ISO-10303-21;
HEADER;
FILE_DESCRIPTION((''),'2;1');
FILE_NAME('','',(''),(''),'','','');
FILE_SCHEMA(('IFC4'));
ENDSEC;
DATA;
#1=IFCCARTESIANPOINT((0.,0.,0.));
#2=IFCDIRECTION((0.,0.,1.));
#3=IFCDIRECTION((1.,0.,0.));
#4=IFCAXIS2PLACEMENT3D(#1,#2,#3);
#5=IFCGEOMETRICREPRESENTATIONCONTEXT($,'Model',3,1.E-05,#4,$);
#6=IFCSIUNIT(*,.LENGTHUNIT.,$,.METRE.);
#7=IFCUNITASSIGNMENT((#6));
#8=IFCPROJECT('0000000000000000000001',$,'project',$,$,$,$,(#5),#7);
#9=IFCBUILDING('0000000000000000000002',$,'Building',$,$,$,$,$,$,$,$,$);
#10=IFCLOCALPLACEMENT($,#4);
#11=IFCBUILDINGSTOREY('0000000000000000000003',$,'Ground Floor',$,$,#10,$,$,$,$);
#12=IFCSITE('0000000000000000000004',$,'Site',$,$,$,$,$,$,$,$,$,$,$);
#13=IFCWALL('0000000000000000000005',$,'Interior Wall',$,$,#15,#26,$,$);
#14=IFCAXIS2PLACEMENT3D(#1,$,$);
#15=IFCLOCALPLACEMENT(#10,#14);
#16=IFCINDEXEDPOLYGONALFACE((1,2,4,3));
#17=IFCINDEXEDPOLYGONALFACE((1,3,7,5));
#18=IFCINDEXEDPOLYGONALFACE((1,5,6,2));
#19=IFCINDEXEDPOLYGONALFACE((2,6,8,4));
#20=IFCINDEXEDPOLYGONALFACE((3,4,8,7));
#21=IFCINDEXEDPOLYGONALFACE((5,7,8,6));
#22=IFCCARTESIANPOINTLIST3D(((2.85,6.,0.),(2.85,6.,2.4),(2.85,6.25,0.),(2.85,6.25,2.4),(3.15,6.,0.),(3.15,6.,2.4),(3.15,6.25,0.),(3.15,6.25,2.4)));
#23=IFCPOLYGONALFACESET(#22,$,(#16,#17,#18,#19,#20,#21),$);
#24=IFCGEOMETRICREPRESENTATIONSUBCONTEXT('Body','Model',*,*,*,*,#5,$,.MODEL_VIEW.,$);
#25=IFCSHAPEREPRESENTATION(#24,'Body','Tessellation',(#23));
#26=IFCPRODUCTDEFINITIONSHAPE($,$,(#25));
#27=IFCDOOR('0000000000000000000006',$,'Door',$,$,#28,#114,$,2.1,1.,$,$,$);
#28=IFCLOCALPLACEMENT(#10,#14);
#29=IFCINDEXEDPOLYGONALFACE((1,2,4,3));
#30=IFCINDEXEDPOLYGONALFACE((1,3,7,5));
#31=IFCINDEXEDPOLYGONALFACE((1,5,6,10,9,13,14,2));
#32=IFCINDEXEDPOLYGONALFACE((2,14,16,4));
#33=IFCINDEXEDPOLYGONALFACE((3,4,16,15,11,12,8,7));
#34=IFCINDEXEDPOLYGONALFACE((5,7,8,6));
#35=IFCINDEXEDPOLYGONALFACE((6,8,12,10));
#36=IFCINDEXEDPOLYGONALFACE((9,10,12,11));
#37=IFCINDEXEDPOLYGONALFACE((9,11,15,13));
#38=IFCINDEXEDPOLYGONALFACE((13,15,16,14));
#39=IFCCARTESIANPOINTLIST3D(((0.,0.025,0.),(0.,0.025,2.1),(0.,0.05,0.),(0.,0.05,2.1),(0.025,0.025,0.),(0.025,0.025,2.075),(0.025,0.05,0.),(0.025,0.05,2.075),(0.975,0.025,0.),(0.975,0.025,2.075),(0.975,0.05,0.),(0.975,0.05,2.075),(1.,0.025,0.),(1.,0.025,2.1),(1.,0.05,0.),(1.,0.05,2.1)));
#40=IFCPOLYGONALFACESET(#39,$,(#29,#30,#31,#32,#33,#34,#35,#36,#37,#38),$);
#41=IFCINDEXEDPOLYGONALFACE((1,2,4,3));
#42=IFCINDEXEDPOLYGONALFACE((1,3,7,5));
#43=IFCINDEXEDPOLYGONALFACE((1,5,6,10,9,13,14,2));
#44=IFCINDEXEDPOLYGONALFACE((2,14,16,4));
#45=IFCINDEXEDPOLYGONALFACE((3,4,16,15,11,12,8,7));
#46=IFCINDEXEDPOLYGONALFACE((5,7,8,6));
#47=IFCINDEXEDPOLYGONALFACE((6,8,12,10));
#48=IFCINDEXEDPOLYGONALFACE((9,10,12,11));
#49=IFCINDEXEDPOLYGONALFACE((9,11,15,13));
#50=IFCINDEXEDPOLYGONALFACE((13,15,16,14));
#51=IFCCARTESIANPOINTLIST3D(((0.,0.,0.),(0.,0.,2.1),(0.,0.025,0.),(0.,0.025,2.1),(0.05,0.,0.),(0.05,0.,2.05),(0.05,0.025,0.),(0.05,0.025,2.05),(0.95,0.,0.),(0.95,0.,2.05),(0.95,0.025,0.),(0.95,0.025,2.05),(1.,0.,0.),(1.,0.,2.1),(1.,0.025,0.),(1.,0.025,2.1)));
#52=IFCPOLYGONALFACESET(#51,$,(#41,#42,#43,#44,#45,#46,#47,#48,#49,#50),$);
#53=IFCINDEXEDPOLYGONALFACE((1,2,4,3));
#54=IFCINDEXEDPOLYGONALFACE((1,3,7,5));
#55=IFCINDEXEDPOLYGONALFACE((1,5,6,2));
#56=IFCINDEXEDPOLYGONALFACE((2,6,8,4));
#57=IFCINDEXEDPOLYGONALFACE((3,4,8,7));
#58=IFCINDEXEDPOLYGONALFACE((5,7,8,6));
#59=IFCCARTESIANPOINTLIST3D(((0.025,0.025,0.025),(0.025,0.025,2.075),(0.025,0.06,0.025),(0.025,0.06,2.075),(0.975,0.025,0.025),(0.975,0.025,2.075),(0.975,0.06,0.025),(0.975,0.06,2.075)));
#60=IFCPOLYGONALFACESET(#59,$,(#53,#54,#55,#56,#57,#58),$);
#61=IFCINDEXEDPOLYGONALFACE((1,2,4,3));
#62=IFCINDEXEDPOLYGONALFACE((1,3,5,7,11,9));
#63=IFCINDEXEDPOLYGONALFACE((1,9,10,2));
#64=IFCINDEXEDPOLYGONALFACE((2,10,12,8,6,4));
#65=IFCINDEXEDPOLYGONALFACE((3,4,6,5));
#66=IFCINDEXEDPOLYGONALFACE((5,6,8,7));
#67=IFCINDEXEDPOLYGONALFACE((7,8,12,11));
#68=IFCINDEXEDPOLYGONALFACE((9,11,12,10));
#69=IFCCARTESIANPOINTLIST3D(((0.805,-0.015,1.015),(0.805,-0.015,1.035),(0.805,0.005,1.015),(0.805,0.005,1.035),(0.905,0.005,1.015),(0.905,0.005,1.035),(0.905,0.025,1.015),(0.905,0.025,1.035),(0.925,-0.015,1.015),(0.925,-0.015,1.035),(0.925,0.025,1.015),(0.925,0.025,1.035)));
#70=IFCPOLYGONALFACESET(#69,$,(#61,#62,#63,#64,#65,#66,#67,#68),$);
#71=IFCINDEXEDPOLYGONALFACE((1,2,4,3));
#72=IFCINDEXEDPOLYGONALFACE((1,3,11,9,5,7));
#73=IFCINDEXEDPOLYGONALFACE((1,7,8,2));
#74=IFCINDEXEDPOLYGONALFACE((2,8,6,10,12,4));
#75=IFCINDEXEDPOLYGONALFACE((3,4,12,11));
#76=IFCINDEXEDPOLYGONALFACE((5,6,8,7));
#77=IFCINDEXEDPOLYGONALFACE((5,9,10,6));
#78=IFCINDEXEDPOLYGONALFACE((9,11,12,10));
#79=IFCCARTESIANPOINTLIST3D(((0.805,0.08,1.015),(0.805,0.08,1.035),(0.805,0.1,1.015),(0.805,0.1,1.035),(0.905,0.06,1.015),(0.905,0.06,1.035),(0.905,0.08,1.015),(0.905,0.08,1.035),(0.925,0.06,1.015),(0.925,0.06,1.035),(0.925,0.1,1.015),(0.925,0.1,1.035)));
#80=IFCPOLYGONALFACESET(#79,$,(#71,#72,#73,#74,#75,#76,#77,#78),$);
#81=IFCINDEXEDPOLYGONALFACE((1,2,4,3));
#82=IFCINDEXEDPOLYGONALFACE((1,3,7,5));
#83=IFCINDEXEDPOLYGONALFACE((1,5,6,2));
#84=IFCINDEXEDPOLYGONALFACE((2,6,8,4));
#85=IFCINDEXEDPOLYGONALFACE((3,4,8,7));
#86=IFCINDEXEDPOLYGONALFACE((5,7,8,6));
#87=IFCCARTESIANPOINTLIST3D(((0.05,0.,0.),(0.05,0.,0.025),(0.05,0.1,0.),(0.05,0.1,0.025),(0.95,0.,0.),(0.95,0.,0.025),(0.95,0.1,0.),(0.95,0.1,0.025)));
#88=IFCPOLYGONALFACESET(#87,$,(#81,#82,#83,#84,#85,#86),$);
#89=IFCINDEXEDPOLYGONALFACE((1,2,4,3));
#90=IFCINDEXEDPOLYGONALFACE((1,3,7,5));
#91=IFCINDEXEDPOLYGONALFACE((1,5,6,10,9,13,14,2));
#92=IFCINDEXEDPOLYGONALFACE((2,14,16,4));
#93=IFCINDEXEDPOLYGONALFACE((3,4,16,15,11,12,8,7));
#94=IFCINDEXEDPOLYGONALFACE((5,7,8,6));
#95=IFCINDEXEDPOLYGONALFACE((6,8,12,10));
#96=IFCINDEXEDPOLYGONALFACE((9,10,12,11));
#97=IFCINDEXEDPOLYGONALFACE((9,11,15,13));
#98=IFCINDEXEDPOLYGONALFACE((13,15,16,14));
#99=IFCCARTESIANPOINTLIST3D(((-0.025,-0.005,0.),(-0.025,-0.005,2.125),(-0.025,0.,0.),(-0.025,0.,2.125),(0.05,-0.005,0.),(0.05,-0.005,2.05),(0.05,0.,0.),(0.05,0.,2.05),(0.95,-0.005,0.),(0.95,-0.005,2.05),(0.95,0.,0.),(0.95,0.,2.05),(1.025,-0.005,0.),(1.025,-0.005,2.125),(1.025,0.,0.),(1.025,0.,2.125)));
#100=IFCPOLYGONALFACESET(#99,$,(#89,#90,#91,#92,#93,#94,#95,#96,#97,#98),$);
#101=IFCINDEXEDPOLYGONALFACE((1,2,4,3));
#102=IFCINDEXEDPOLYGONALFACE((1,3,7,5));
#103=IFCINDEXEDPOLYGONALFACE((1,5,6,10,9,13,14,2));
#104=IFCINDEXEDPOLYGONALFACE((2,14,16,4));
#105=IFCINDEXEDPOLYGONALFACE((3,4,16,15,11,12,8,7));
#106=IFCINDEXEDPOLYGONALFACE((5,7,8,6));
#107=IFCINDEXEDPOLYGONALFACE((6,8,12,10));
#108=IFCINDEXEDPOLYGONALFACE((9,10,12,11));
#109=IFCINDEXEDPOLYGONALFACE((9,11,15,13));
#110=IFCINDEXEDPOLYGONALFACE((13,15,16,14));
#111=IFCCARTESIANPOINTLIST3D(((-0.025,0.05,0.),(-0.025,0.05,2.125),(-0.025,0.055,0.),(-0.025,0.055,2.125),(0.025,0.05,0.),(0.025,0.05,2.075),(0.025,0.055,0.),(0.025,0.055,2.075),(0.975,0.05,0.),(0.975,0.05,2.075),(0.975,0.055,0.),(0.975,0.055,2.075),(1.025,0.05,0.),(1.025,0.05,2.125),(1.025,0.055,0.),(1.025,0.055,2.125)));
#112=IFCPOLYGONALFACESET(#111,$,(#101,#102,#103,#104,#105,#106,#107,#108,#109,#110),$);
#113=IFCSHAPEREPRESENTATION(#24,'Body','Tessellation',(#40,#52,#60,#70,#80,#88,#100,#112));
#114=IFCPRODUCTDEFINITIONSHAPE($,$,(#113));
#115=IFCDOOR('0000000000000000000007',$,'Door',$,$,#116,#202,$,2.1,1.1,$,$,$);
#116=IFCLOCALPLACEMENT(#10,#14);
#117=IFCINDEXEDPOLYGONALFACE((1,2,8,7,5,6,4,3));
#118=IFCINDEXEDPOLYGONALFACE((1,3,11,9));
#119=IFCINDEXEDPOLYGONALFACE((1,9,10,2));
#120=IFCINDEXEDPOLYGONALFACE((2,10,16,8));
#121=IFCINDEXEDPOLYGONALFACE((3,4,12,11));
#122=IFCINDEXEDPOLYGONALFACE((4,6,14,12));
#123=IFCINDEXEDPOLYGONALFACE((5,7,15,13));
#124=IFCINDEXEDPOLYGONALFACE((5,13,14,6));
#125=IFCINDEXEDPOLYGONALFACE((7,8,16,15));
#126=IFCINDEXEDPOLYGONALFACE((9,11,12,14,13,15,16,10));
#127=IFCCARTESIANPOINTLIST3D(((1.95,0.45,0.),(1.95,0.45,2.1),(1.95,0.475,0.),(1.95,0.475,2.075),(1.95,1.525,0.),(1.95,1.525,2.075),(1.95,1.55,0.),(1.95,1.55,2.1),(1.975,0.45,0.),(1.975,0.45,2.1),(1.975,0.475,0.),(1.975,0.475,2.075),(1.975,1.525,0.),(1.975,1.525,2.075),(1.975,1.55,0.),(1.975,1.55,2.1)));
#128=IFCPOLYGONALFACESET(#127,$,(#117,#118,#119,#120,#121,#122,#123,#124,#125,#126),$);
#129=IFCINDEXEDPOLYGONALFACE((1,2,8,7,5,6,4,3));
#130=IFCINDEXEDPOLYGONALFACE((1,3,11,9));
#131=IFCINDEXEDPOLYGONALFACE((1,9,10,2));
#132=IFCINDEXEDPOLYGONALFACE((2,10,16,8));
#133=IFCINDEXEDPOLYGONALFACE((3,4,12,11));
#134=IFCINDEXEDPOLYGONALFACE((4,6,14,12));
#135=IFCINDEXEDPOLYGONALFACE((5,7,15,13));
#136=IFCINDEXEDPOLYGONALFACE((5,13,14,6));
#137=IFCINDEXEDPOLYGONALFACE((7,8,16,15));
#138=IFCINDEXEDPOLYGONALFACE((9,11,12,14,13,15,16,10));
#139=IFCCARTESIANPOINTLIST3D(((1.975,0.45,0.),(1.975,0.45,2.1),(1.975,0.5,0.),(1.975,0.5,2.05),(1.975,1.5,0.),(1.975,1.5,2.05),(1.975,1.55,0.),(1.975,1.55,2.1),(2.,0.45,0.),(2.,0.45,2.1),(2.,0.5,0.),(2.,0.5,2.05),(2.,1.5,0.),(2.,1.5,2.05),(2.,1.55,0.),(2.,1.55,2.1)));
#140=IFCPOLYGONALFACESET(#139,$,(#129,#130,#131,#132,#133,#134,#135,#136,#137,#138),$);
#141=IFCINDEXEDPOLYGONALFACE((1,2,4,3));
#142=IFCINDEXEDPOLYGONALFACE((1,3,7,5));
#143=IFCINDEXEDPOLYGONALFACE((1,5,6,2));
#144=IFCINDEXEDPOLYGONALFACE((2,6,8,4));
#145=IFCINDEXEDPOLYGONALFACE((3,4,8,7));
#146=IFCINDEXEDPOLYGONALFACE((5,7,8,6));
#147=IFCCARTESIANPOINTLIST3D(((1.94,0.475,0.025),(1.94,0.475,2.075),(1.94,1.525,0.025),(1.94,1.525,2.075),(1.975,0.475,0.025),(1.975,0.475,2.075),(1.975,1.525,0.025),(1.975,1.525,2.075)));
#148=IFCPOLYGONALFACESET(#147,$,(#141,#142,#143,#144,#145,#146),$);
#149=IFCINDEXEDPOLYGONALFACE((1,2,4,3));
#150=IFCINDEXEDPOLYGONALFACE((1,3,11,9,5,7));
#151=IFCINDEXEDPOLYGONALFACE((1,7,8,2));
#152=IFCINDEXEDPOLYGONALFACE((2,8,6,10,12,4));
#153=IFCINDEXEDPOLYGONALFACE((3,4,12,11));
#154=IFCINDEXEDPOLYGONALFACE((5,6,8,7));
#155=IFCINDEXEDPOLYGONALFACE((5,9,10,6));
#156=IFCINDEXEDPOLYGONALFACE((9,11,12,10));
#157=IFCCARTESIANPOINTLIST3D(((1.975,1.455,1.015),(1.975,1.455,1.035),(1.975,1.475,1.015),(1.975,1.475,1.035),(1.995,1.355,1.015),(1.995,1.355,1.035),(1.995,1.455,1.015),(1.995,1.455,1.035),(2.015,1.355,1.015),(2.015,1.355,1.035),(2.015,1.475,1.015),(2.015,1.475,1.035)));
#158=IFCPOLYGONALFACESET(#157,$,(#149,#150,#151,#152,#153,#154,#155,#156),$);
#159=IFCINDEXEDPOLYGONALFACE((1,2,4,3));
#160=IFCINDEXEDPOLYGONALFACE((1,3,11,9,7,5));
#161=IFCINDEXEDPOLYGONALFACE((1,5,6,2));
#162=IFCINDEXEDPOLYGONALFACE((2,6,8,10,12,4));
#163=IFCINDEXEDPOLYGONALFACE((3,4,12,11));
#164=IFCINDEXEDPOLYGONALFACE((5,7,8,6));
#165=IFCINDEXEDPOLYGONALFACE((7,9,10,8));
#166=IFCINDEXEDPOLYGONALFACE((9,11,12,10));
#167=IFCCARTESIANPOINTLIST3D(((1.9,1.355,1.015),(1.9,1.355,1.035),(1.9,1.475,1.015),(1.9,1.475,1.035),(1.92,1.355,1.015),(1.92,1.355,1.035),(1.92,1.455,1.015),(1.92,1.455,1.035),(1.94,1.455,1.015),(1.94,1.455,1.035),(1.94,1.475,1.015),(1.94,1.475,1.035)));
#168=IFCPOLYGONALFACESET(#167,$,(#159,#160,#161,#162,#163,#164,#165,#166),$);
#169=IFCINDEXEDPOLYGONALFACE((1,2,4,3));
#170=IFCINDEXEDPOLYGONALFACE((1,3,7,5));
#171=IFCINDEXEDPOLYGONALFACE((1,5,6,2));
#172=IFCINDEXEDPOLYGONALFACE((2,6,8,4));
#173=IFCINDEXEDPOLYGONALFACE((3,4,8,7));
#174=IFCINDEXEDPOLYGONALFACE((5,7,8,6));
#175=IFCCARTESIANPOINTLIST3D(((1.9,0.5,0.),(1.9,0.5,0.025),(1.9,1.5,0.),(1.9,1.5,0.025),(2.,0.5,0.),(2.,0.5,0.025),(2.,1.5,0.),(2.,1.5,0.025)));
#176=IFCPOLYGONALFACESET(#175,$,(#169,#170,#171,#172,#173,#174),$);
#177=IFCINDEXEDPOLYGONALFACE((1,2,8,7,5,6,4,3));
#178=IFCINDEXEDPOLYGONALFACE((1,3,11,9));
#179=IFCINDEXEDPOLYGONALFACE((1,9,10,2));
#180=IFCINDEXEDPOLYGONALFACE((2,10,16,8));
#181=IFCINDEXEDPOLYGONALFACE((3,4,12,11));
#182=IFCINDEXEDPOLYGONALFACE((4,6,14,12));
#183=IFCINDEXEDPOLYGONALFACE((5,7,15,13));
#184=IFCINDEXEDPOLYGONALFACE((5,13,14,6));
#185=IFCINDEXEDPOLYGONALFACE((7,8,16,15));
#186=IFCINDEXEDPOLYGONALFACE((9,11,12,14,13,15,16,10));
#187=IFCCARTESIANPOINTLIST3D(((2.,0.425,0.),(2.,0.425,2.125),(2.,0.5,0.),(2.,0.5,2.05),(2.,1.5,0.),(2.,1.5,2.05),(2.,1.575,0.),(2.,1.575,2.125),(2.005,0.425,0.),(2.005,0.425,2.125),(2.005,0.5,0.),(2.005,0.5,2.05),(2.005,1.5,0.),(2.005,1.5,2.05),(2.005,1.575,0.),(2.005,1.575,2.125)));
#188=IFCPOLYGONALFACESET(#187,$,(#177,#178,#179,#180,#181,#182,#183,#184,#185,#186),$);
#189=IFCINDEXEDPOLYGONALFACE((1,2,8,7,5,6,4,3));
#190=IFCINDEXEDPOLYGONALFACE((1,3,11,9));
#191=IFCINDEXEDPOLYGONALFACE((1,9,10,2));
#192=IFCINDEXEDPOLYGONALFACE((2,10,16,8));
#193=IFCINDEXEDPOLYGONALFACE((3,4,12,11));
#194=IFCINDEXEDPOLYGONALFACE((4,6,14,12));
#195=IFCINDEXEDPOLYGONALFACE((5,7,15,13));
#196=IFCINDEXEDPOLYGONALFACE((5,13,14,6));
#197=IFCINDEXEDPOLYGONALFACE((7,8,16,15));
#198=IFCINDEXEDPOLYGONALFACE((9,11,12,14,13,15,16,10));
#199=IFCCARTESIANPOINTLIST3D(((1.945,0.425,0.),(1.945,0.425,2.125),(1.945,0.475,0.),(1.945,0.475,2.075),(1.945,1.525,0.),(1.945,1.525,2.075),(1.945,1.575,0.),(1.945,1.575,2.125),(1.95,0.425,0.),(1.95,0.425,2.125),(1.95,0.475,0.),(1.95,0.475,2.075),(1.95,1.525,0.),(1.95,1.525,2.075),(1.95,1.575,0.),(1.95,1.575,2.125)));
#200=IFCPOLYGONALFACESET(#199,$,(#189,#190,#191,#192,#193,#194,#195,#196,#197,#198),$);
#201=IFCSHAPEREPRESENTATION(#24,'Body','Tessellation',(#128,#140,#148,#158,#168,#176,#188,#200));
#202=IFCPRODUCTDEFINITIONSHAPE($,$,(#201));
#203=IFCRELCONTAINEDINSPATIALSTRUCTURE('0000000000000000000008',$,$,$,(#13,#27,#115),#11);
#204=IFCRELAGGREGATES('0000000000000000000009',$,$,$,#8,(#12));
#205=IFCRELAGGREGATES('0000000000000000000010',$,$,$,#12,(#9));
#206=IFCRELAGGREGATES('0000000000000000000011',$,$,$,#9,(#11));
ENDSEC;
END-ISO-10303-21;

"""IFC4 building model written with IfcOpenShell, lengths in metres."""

from ifc_helpers import new_model, si_unit, frame, origin_with_axes, place, context, subcontext, project, spatial, line, indexed_curve, outline, extrude, element, save


model = new_model("IFC4")

# Units and contexts
model_context = context("Model", 3, precision=1e-05, world=origin_with_axes())
body_context = subcontext(model_context, "Body", "Model", "MODEL_VIEW")
ifc_project = project(units=[si_unit("LENGTHUNIT", "METRE")], contexts=[model_context])

# Site, building, storey
site = spatial("IfcSite", under=ifc_project, Name="Site")
building = spatial("IfcBuilding", under=site, Name="Building")
storey_placement = place(None, origin_with_axes())
storey = spatial("IfcBuildingStorey", under=building, at=storey_placement, Name="Ground Floor")

# Wall
wall_1_placement = place(storey_placement, frame((3.0, 6.0, 0.0), z_axis=(0.0, 0.0, 1.0), x_axis=(0.0, 1.0, 0.0)))
element("IfcWall", 1, at=wall_1_placement, inside=storey, Name="Interior Wall", context=body_context, shape_type="SweptSolid", body=[
    extrude(outline(indexed_curve([(0.0, 0.0), (0.0, 0.3), (0.25, 0.3), (0.25, 0.0), (0.0, 0.0)], self_intersect=False)), frame((0.0, -0.15, 0.0), z_axis=(0.0, 0.0, 1.0), x_axis=(1.0, 0.0, 0.0)), (0.0, 0.0, 1.0), 2.4),
])

# Doors
door_1_placement = place(storey_placement, origin_with_axes())
element("IfcDoor", 2, at=door_1_placement, inside=storey, Name="Door", OverallHeight=2.1, OverallWidth=1.0, context=body_context, shape_type="SweptSolid", body=[
    extrude(outline(indexed_curve([(0.0, 0.0), (0.0, 2.1), (1.0, 2.1), (1.0, 0.0), (0.975, 0.0), (0.975, 2.075), (0.025, 2.075), (0.025, 0.0)], segments=[line(1, 2, 3, 4, 5, 6, 7, 8, 1)])), frame((0.0, 0.025, 0.0), z_axis=(0.0, -1.0, 0.0), x_axis=(1.0, 0.0, 0.0)), (0.0, 0.0, -1.0), 0.025),
    extrude(outline(indexed_curve([(0.0, 0.0), (0.0, 2.1), (1.0, 2.1), (1.0, 0.0), (0.95, 0.0), (0.95, 2.05), (0.05, 2.05), (0.05, 0.0)], segments=[line(1, 2, 3, 4, 5, 6, 7, 8, 1)])), frame((0.0, 0.0, 0.0), z_axis=(0.0, -1.0, 0.0), x_axis=(1.0, 0.0, 0.0)), (0.0, 0.0, -1.0), 0.025),
    extrude(outline(indexed_curve([(0.0, 0.0), (0.95, 0.0), (0.95, 0.035), (0.0, 0.035)], segments=[line(1, 2, 3, 4, 1)])), frame((0.025, 0.025, 0.025), z_axis=(0.0, 0.0, 1.0), x_axis=(1.0, 0.0, 0.0)), (0.0, 0.0, 1.0), 2.05),
    extrude(outline(indexed_curve([(0.0, 0.0), (0.0, -0.04), (-0.12, -0.04), (-0.12, -0.02), (-0.02, -0.02), (-0.02, 0.0)], segments=[line(1, 2, 3, 4, 5, 6, 1)])), frame((0.925, 0.025, 1.015), z_axis=(0.0, 0.0, 1.0), x_axis=(1.0, 0.0, 0.0)), (0.0, 0.0, 1.0), 0.02),
    extrude(outline(indexed_curve([(0.0, 0.0), (0.0, 0.04), (-0.12, 0.04), (-0.12, 0.02), (-0.02, 0.02), (-0.02, 0.0)], segments=[line(1, 2, 3, 4, 5, 6, 1)])), frame((0.925, 0.06, 1.015), z_axis=(0.0, 0.0, 1.0), x_axis=(1.0, 0.0, 0.0)), (0.0, 0.0, 1.0), 0.02),
    extrude(outline(indexed_curve([(0.0, 0.0), (0.9, 0.0), (0.9, 0.1), (0.0, 0.1)], segments=[line(1, 2, 3, 4, 1)])), frame((0.05, 0.0, 0.0), z_axis=(0.0, 0.0, 1.0), x_axis=(1.0, 0.0, 0.0)), (0.0, 0.0, 1.0), 0.025),
    extrude(outline(indexed_curve([(0.0, 0.0), (0.0, 2.125), (1.05, 2.125), (1.05, 0.0), (0.975, 0.0), (0.975, 2.05), (0.075, 2.05), (0.075, 0.0)], segments=[line(1, 2, 3, 4, 5, 6, 7, 8, 1)])), frame((-0.025, -0.005, 0.0), z_axis=(0.0, -1.0, 0.0), x_axis=(1.0, 0.0, 0.0)), (0.0, 0.0, -1.0), 0.005),
    extrude(outline(indexed_curve([(0.0, 0.0), (0.0, 2.125), (1.05, 2.125), (1.05, 0.0), (1.0, 0.0), (1.0, 2.075), (0.05, 2.075), (0.05, 0.0)], segments=[line(1, 2, 3, 4, 5, 6, 7, 8, 1)])), frame((-0.025, 0.05, 0.0), z_axis=(0.0, -1.0, 0.0), x_axis=(1.0, 0.0, 0.0)), (0.0, 0.0, -1.0), 0.005),
])
door_2_placement = place(storey_placement, frame((2.0, 0.45, 0.0), z_axis=(0.0, 0.0, 1.0), x_axis=(0.0, 1.0, 0.0)))
element("IfcDoor", 3, at=door_2_placement, inside=storey, Name="Door", OverallHeight=2.1, OverallWidth=1.1, context=body_context, shape_type="SweptSolid", body=[
    extrude(outline(indexed_curve([(0.0, 0.0), (0.0, 2.1), (1.1, 2.1), (1.1, 0.0), (1.075, 0.0), (1.075, 2.075), (0.025, 2.075), (0.025, 0.0)], segments=[line(1, 2, 3, 4, 5, 6, 7, 8, 1)])), frame((0.0, 0.025, 0.0), z_axis=(0.0, -1.0, 0.0), x_axis=(1.0, 0.0, 0.0)), (0.0, 0.0, -1.0), 0.025),
    extrude(outline(indexed_curve([(0.0, 0.0), (0.0, 2.1), (1.1, 2.1), (1.1, 0.0), (1.05, 0.0), (1.05, 2.05), (0.05, 2.05), (0.05, 0.0)], segments=[line(1, 2, 3, 4, 5, 6, 7, 8, 1)])), frame((0.0, 0.0, 0.0), z_axis=(0.0, -1.0, 0.0), x_axis=(1.0, 0.0, 0.0)), (0.0, 0.0, -1.0), 0.025),
    extrude(outline(indexed_curve([(0.0, 0.0), (1.05, 0.0), (1.05, 0.035), (0.0, 0.035)], segments=[line(1, 2, 3, 4, 1)])), frame((0.025, 0.025, 0.025), z_axis=(0.0, 0.0, 1.0), x_axis=(1.0, 0.0, 0.0)), (0.0, 0.0, 1.0), 2.05),
    extrude(outline(indexed_curve([(0.0, 0.0), (0.0, -0.04), (-0.12, -0.04), (-0.12, -0.02), (-0.02, -0.02), (-0.02, 0.0)], segments=[line(1, 2, 3, 4, 5, 6, 1)])), frame((1.025, 0.025, 1.015), z_axis=(0.0, 0.0, 1.0), x_axis=(1.0, 0.0, 0.0)), (0.0, 0.0, 1.0), 0.02),
    extrude(outline(indexed_curve([(0.0, 0.0), (0.0, 0.04), (-0.12, 0.04), (-0.12, 0.02), (-0.02, 0.02), (-0.02, 0.0)], segments=[line(1, 2, 3, 4, 5, 6, 1)])), frame((1.025, 0.06, 1.015), z_axis=(0.0, 0.0, 1.0), x_axis=(1.0, 0.0, 0.0)), (0.0, 0.0, 1.0), 0.02),
    extrude(outline(indexed_curve([(0.0, 0.0), (1.0, 0.0), (1.0, 0.1), (0.0, 0.1)], segments=[line(1, 2, 3, 4, 1)])), frame((0.05, 0.0, 0.0), z_axis=(0.0, 0.0, 1.0), x_axis=(1.0, 0.0, 0.0)), (0.0, 0.0, 1.0), 0.025),
    extrude(outline(indexed_curve([(0.0, 0.0), (0.0, 2.125), (1.15, 2.125), (1.15, 0.0), (1.075, 0.0), (1.075, 2.05), (0.075, 2.05), (0.075, 0.0)], segments=[line(1, 2, 3, 4, 5, 6, 7, 8, 1)])), frame((-0.025, -0.005, 0.0), z_axis=(0.0, -1.0, 0.0), x_axis=(1.0, 0.0, 0.0)), (0.0, 0.0, -1.0), 0.005),
    extrude(outline(indexed_curve([(0.0, 0.0), (0.0, 2.125), (1.15, 2.125), (1.15, 0.0), (1.1, 0.0), (1.1, 2.075), (0.05, 2.075), (0.05, 0.0)], segments=[line(1, 2, 3, 4, 5, 6, 7, 8, 1)])), frame((-0.025, 0.05, 0.0), z_axis=(0.0, -1.0, 0.0), x_axis=(1.0, 0.0, 0.0)), (0.0, 0.0, -1.0), 0.005),
])

save(model, "model.ifc")
